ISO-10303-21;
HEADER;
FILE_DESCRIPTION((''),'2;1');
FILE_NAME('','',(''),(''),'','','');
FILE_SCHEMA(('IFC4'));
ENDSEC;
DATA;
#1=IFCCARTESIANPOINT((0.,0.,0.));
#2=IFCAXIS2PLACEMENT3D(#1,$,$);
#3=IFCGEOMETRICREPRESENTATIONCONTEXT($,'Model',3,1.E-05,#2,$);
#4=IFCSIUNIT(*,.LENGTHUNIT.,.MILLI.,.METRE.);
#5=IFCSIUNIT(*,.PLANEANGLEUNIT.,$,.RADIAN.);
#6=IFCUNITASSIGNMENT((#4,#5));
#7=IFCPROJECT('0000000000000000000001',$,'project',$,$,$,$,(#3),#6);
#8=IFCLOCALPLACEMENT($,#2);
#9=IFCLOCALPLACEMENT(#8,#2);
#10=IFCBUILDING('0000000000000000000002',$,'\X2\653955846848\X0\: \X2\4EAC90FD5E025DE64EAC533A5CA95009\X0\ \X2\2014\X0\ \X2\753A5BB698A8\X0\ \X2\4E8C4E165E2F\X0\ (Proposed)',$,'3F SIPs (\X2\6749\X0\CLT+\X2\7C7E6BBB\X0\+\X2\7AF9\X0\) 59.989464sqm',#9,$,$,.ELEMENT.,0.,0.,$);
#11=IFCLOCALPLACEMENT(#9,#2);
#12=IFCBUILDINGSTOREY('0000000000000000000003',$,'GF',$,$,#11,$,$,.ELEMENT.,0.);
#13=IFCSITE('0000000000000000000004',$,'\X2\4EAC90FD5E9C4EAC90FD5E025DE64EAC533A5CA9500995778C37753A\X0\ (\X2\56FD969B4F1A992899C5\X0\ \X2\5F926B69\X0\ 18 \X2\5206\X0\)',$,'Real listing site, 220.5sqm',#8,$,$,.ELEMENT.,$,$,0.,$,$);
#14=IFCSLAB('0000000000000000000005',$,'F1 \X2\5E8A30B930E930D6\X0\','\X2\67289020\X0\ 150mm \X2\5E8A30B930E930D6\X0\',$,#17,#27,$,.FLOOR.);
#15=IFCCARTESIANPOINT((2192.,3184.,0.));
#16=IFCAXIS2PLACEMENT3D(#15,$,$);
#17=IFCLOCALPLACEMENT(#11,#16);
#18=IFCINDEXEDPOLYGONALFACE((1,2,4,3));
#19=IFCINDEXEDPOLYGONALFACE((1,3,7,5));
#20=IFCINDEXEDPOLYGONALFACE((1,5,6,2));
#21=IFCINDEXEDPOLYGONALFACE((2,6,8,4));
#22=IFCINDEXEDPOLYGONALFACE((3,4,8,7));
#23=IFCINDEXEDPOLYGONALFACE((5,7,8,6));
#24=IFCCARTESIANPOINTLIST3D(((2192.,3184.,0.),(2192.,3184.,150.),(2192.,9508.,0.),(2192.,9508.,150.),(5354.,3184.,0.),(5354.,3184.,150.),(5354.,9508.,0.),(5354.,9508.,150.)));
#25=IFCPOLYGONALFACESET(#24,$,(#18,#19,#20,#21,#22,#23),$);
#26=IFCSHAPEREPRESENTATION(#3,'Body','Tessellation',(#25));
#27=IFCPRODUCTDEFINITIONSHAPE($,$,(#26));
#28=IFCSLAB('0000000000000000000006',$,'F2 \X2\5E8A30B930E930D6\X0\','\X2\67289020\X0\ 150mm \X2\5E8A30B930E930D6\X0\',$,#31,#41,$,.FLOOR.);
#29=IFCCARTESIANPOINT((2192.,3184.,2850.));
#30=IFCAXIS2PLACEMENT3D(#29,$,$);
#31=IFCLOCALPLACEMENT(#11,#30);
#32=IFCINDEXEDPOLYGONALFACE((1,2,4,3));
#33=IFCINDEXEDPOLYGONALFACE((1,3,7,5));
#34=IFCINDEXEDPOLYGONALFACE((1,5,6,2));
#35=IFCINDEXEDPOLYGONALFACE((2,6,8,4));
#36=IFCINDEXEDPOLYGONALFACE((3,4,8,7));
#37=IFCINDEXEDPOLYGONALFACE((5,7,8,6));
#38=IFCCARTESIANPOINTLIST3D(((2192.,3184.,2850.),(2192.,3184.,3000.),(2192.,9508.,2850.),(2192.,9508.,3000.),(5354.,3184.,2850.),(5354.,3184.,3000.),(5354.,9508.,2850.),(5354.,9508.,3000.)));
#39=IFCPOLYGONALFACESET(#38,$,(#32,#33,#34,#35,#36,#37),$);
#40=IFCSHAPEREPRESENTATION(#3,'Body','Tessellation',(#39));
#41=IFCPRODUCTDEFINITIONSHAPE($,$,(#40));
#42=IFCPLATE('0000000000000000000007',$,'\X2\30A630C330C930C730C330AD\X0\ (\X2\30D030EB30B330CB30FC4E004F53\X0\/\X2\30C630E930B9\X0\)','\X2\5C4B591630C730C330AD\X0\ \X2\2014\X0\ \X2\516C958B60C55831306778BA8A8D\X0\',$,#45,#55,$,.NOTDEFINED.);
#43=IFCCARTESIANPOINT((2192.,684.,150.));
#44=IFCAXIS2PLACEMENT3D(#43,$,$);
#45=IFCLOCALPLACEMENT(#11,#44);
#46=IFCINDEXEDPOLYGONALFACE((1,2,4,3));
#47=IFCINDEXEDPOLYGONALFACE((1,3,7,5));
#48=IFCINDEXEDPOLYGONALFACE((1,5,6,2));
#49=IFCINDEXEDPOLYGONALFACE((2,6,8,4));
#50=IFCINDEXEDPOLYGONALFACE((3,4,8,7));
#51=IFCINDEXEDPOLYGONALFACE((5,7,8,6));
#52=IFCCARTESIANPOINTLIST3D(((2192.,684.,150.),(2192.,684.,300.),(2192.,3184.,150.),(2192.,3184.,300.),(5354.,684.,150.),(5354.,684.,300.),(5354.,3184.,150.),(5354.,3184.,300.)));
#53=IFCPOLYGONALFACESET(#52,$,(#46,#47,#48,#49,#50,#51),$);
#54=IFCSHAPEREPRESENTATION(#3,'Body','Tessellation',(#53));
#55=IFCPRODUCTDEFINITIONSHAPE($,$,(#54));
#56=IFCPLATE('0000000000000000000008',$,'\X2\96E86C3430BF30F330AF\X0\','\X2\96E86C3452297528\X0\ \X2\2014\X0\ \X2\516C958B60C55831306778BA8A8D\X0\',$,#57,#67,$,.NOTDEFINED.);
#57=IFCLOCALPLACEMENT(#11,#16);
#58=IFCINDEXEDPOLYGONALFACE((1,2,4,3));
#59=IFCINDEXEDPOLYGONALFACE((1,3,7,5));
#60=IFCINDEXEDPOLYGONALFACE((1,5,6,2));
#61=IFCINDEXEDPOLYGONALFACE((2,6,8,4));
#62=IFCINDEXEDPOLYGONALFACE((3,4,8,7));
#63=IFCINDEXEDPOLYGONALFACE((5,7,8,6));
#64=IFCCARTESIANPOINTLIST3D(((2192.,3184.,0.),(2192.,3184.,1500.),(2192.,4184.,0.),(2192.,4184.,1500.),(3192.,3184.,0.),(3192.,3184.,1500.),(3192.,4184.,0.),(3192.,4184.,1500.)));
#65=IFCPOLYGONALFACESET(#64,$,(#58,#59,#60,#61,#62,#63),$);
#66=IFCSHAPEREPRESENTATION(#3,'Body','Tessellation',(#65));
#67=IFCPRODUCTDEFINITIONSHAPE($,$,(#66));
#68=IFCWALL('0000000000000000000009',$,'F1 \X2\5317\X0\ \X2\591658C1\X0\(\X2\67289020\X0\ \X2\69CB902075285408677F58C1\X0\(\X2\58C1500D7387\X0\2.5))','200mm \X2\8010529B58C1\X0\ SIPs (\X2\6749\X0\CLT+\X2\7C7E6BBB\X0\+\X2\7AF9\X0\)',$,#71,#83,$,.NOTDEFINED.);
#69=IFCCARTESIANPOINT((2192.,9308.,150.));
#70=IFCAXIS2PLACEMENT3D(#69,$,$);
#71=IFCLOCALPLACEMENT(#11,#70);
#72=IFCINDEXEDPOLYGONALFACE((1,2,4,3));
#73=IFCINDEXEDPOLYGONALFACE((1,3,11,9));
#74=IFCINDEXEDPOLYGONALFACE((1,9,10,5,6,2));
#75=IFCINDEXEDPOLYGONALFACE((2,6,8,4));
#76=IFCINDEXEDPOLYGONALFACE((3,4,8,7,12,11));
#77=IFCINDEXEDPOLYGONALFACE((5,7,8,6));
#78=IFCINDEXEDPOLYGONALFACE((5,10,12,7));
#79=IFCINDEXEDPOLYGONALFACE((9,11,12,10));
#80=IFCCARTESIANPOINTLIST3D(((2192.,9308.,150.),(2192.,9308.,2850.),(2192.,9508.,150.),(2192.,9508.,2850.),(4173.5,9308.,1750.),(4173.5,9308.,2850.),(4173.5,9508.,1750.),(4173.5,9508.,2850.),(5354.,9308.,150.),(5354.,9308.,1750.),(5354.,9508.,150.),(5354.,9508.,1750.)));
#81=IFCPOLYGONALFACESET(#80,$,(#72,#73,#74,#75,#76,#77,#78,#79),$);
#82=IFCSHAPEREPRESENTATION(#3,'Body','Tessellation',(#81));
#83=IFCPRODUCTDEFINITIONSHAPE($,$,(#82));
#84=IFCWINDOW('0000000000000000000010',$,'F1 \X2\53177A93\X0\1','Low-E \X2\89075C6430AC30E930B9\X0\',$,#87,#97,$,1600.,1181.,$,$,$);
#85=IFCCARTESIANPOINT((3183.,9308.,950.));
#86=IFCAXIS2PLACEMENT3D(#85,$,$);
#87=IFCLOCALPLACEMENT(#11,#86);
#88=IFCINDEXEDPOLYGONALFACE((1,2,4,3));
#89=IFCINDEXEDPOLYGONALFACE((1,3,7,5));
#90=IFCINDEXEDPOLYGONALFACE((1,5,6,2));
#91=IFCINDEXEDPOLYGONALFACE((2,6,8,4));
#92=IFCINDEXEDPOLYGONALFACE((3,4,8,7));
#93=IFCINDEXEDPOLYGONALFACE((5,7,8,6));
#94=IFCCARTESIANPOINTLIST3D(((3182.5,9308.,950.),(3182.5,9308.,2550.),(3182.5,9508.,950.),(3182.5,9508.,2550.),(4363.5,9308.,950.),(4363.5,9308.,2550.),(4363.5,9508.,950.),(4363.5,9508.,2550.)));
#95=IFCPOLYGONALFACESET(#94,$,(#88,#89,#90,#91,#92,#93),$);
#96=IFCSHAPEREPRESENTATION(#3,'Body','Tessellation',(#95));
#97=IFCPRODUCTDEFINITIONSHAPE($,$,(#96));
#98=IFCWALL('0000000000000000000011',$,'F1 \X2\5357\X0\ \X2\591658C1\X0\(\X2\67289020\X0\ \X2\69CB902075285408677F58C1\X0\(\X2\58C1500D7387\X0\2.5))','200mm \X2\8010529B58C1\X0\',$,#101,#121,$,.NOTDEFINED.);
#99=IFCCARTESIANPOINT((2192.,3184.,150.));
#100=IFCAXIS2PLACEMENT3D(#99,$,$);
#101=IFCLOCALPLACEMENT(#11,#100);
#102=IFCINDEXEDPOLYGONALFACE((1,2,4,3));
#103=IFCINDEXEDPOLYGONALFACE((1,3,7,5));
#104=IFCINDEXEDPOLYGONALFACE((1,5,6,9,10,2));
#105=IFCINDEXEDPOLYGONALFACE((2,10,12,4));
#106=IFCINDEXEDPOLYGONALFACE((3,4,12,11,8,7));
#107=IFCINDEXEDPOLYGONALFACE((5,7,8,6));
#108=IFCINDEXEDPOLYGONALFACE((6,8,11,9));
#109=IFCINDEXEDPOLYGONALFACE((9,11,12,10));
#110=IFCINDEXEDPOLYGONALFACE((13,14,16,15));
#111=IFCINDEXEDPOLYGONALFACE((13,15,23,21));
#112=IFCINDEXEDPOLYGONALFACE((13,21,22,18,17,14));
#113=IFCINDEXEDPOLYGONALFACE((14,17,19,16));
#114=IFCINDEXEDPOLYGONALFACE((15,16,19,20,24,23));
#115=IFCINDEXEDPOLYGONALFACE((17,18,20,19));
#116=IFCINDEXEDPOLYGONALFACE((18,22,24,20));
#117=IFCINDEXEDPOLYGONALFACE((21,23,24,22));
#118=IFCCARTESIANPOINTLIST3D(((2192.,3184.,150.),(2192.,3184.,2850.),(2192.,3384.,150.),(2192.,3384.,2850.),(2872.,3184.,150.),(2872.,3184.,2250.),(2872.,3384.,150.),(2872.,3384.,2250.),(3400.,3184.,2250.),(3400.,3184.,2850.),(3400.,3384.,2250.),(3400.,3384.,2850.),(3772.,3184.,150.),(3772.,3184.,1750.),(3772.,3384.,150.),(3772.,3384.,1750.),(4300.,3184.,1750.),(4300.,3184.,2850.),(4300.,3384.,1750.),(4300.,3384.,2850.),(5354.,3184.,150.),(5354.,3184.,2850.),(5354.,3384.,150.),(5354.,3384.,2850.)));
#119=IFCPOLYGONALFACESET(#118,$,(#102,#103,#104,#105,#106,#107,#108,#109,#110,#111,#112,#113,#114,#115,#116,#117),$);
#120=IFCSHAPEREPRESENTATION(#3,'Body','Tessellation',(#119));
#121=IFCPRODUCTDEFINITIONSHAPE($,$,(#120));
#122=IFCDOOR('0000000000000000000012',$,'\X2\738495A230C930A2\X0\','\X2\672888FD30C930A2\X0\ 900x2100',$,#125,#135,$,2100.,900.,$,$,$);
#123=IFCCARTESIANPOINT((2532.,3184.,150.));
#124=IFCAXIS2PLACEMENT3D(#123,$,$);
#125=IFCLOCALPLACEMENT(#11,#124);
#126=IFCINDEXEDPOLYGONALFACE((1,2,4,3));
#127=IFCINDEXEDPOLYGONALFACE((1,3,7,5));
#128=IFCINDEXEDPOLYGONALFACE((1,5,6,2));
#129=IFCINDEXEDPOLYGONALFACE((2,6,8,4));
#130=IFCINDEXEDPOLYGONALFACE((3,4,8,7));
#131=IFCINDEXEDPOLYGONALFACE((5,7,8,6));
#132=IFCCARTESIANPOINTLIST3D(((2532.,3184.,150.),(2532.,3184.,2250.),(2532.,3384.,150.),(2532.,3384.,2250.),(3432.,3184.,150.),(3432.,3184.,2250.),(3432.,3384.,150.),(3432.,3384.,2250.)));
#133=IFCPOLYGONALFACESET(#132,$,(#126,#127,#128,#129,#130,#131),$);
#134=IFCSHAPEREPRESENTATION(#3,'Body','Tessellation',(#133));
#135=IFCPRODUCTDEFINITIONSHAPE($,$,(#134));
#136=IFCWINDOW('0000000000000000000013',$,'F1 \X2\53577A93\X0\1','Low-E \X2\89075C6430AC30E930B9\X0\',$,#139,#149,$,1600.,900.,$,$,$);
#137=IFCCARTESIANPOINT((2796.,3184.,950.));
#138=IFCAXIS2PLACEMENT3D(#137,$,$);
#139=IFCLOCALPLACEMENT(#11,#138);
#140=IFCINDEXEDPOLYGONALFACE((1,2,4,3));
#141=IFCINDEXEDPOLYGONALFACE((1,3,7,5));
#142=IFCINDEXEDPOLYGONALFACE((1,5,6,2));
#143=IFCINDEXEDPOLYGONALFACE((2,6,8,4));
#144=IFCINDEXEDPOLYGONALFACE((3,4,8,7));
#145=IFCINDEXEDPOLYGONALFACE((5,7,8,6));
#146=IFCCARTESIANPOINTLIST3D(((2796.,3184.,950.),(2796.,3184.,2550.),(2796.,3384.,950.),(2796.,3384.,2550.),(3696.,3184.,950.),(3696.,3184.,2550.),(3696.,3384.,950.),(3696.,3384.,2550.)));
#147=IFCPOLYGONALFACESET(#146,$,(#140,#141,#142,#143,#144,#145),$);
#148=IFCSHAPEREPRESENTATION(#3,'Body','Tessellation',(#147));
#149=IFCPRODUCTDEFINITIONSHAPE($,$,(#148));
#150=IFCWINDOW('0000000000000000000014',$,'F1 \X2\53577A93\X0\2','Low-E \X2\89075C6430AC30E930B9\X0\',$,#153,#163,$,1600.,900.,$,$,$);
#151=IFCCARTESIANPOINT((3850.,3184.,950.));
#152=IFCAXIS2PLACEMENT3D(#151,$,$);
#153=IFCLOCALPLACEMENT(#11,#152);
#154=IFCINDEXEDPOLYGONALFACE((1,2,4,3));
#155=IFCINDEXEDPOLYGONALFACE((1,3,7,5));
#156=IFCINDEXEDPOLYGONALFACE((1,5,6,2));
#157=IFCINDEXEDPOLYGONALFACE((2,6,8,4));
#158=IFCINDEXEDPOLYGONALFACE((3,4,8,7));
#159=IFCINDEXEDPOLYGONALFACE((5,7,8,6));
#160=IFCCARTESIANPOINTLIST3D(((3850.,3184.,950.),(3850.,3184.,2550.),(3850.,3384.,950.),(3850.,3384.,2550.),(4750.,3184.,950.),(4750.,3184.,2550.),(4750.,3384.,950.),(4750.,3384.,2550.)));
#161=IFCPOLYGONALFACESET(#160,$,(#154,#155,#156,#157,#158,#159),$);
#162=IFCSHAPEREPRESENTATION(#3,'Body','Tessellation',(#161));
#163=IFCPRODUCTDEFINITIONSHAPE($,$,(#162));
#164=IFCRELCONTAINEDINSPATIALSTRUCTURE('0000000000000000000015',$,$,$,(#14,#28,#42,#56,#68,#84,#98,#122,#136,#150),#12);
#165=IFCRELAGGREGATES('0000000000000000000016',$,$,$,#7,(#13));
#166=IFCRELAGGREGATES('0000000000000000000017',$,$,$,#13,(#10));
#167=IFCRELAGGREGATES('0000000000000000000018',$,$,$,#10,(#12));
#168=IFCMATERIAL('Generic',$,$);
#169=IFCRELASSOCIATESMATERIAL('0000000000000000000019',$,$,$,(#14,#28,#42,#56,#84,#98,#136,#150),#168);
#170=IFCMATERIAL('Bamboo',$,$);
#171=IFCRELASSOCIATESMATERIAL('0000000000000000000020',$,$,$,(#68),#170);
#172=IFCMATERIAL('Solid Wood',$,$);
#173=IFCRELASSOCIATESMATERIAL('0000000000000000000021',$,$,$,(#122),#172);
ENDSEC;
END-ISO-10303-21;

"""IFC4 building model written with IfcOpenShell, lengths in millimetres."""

from ifc_helpers import new_model, si_unit, frame, frame_2d, origin, place, context, project, spatial, rectangle, extrude, material, element, fill, save


model = new_model("IFC4")

# Units and contexts
model_context = context("Model", 3, precision=1e-05, world=origin())
ifc_project = project(units=[si_unit("LENGTHUNIT", "METRE", prefix="MILLI"), si_unit("PLANEANGLEUNIT", "RADIAN")], contexts=[model_context])

# Site, building, storey
site_placement = place(None, origin())
site = spatial("IfcSite", under=ifc_project, at=site_placement, Name="京都府京都市左京区岩倉長谷町 (国際会館駅 徒歩 18 分)", ObjectType="Real listing site, 220.5sqm", CompositionType="ELEMENT", RefElevation=0.0)
building_placement = place(site_placement, origin())
building = spatial("IfcBuilding", under=site, at=building_placement, Name="改善案: 京都市左京区岩倉 — 町家風 二世帯 (Proposed)", ObjectType="3F SIPs (杉CLT+籾殻+竹) 59.989464sqm", CompositionType="ELEMENT", ElevationOfRefHeight=0.0, ElevationOfTerrain=0.0)
storey_placement = place(building_placement, origin())
storey = spatial("IfcBuildingStorey", under=building, at=storey_placement, Name="GF", CompositionType="ELEMENT", Elevation=0.0)

# Slabs
ifc_material_1 = material(Name="Generic")
slab_1_placement = place(storey_placement, frame((2192.0, 3184.0, 0.0)))
element("IfcSlab", 1, at=slab_1_placement, inside=storey, material=ifc_material_1, Name="F1 床スラブ", Description="木造 150mm 床スラブ", PredefinedType="FLOOR", context=model_context, shape_type="SweptSolid", body=[
    extrude(rectangle(XDim=3162.0, YDim=6324.0, at=frame_2d((1581.0, 3162.0))), frame((2192.0, 3184.0, 0.0)), (0.0, 0.0, 1.0), 150.0),
])
slab_2_placement = place(storey_placement, frame((2192.0, 3184.0, 2850.0)))
element("IfcSlab", 2, at=slab_2_placement, inside=storey, material=ifc_material_1, Name="F2 床スラブ", Description="木造 150mm 床スラブ", PredefinedType="FLOOR", context=model_context, shape_type="SweptSolid", body=[
    extrude(rectangle(XDim=3162.0, YDim=6324.0, at=frame_2d((1581.0, 3162.0))), frame((2192.0, 3184.0, 2850.0)), (0.0, 0.0, 1.0), 150.0),
])

# Plates
plate_1_placement = place(storey_placement, frame((2192.0, 684.0, 150.0)))
element("IfcPlate", 3, at=plate_1_placement, inside=storey, material=ifc_material_1, Name="ウッドデッキ (バルコニー一体/テラス)", Description="屋外デッキ — 公開情報で確認", PredefinedType="NOTDEFINED", context=model_context, shape_type="SweptSolid", body=[
    extrude(rectangle(XDim=3162.0, YDim=2500.0, at=frame_2d((1581.0, 1250.0))), frame((2192.0, 684.0, 150.0)), (0.0, 0.0, 1.0), 150.0),
])
plate_2_placement = place(storey_placement, frame((2192.0, 3184.0, 0.0)))
element("IfcPlate", 4, at=plate_2_placement, inside=storey, material=ifc_material_1, Name="雨水タンク", Description="雨水利用 — 公開情報で確認", PredefinedType="NOTDEFINED", context=model_context, shape_type="SweptSolid", body=[
    extrude(rectangle(XDim=1000.0, YDim=1000.0, at=frame_2d((500.0, 500.0))), frame((2192.0, 3184.0, 0.0)), (0.0, 0.0, 1.0), 1500.0),
])

# Wall, opening, window
ifc_material_2 = material(Name="Bamboo")
wall_1_placement = place(storey_placement, frame((2192.0, 9308.0, 150.0)))
wall_1 = element("IfcWall", 5, at=wall_1_placement, inside=storey, material=ifc_material_2, Name="F1 北 外壁(木造 構造用合板壁(壁倍率2.5))", Description="200mm 耐力壁 SIPs (杉CLT+籾殻+竹)", PredefinedType="NOTDEFINED", context=model_context, shape_type="SweptSolid", body=[
    extrude(rectangle(XDim=3162.0, YDim=200.0, at=frame_2d((1581.0, 100.0))), frame((2192.0, 9308.0, 150.0)), (0.0, 0.0, 1.0), 2700.0),
])
opening_1_placement = place(storey_placement, frame((3183.0, 9308.0, 950.0)))
opening_1 = element("IfcOpeningElement", 6, at=opening_1_placement, cuts=wall_1, PredefinedType="NOTDEFINED", context=model_context, shape_type="SweptSolid", body=[
    extrude(rectangle(XDim=1181.0, YDim=200.0, at=frame_2d((590.0, 100.0))), frame((3183.0, 9308.0, 950.0)), (0.0, 0.0, 1.0), 1600.0),
])
window_1_placement = place(storey_placement, frame((3183.0, 9308.0, 950.0)))
window_1 = element("IfcWindow", 7, at=window_1_placement, inside=storey, material=ifc_material_1, Name="F1 北窓1", Description="Low-E 複層ガラス", OverallHeight=1600.0, OverallWidth=1181.0, context=model_context, shape_type="SweptSolid", body=[
    extrude(rectangle(XDim=1181.0, YDim=200.0, at=frame_2d((590.0, 100.0))), frame((3183.0, 9308.0, 950.0)), (0.0, 0.0, 1.0), 1600.0),
])
fill(opening_1, window_1)

# Wall, openings, door, windows
wall_2_placement = place(storey_placement, frame((2192.0, 3184.0, 150.0)))
wall_2 = element("IfcWall", 8, at=wall_2_placement, inside=storey, material=ifc_material_1, Name="F1 南 外壁(木造 構造用合板壁(壁倍率2.5))", Description="200mm 耐力壁", PredefinedType="NOTDEFINED", context=model_context, shape_type="SweptSolid", body=[
    extrude(rectangle(XDim=3162.0, YDim=200.0, at=frame_2d((1581.0, 100.0))), frame((2192.0, 3184.0, 150.0)), (0.0, 0.0, 1.0), 2700.0),
])
opening_2_placement = place(storey_placement, frame((2532.0, 3184.0, 150.0)))
opening_2 = element("IfcOpeningElement", 9, at=opening_2_placement, cuts=wall_2, PredefinedType="NOTDEFINED", context=model_context, shape_type="SweptSolid", body=[
    extrude(rectangle(XDim=900.0, YDim=200.0, at=frame_2d((450.0, 100.0))), frame((2532.0, 3184.0, 150.0)), (0.0, 0.0, 1.0), 2100.0),
])
opening_3_placement = place(storey_placement, frame((2796.0, 3184.0, 950.0)))
opening_3 = element("IfcOpeningElement", 10, at=opening_3_placement, cuts=wall_2, PredefinedType="NOTDEFINED", context=model_context, shape_type="SweptSolid", body=[
    extrude(rectangle(XDim=900.0, YDim=200.0, at=frame_2d((450.0, 100.0))), frame((2796.0, 3184.0, 950.0)), (0.0, 0.0, 1.0), 1600.0),
])
opening_4_placement = place(storey_placement, frame((3850.0, 3184.0, 950.0)))
opening_4 = element("IfcOpeningElement", 11, at=opening_4_placement, cuts=wall_2, PredefinedType="NOTDEFINED", context=model_context, shape_type="SweptSolid", body=[
    extrude(rectangle(XDim=900.0, YDim=200.0, at=frame_2d((450.0, 100.0))), frame((3850.0, 3184.0, 950.0)), (0.0, 0.0, 1.0), 1600.0),
])
ifc_material_3 = material(Name="Solid Wood")
door_placement = place(storey_placement, frame((2532.0, 3184.0, 150.0)))
door = element("IfcDoor", 12, at=door_placement, inside=storey, material=ifc_material_3, Name="玄関ドア", Description="木製ドア 900x2100", OverallHeight=2100.0, OverallWidth=900.0, context=model_context, shape_type="SweptSolid", body=[
    extrude(rectangle(XDim=900.0, YDim=200.0, at=frame_2d((450.0, 100.0))), frame((2532.0, 3184.0, 150.0)), (0.0, 0.0, 1.0), 2100.0),
])
fill(opening_2, door)
window_2_placement = place(storey_placement, frame((2796.0, 3184.0, 950.0)))
window_2 = element("IfcWindow", 13, at=window_2_placement, inside=storey, material=ifc_material_1, Name="F1 南窓1", Description="Low-E 複層ガラス", OverallHeight=1600.0, OverallWidth=900.0, context=model_context, shape_type="SweptSolid", body=[
    extrude(rectangle(XDim=900.0, YDim=200.0, at=frame_2d((450.0, 100.0))), frame((2796.0, 3184.0, 950.0)), (0.0, 0.0, 1.0), 1600.0),
])
fill(opening_3, window_2)
window_3_placement = place(storey_placement, frame((3850.0, 3184.0, 950.0)))
window_3 = element("IfcWindow", 14, at=window_3_placement, inside=storey, material=ifc_material_1, Name="F1 南窓2", Description="Low-E 複層ガラス", OverallHeight=1600.0, OverallWidth=900.0, context=model_context, shape_type="SweptSolid", body=[
    extrude(rectangle(XDim=900.0, YDim=200.0, at=frame_2d((450.0, 100.0))), frame((3850.0, 3184.0, 950.0)), (0.0, 0.0, 1.0), 1600.0),
])
fill(opening_4, window_3)

save(model, "model.ifc")
